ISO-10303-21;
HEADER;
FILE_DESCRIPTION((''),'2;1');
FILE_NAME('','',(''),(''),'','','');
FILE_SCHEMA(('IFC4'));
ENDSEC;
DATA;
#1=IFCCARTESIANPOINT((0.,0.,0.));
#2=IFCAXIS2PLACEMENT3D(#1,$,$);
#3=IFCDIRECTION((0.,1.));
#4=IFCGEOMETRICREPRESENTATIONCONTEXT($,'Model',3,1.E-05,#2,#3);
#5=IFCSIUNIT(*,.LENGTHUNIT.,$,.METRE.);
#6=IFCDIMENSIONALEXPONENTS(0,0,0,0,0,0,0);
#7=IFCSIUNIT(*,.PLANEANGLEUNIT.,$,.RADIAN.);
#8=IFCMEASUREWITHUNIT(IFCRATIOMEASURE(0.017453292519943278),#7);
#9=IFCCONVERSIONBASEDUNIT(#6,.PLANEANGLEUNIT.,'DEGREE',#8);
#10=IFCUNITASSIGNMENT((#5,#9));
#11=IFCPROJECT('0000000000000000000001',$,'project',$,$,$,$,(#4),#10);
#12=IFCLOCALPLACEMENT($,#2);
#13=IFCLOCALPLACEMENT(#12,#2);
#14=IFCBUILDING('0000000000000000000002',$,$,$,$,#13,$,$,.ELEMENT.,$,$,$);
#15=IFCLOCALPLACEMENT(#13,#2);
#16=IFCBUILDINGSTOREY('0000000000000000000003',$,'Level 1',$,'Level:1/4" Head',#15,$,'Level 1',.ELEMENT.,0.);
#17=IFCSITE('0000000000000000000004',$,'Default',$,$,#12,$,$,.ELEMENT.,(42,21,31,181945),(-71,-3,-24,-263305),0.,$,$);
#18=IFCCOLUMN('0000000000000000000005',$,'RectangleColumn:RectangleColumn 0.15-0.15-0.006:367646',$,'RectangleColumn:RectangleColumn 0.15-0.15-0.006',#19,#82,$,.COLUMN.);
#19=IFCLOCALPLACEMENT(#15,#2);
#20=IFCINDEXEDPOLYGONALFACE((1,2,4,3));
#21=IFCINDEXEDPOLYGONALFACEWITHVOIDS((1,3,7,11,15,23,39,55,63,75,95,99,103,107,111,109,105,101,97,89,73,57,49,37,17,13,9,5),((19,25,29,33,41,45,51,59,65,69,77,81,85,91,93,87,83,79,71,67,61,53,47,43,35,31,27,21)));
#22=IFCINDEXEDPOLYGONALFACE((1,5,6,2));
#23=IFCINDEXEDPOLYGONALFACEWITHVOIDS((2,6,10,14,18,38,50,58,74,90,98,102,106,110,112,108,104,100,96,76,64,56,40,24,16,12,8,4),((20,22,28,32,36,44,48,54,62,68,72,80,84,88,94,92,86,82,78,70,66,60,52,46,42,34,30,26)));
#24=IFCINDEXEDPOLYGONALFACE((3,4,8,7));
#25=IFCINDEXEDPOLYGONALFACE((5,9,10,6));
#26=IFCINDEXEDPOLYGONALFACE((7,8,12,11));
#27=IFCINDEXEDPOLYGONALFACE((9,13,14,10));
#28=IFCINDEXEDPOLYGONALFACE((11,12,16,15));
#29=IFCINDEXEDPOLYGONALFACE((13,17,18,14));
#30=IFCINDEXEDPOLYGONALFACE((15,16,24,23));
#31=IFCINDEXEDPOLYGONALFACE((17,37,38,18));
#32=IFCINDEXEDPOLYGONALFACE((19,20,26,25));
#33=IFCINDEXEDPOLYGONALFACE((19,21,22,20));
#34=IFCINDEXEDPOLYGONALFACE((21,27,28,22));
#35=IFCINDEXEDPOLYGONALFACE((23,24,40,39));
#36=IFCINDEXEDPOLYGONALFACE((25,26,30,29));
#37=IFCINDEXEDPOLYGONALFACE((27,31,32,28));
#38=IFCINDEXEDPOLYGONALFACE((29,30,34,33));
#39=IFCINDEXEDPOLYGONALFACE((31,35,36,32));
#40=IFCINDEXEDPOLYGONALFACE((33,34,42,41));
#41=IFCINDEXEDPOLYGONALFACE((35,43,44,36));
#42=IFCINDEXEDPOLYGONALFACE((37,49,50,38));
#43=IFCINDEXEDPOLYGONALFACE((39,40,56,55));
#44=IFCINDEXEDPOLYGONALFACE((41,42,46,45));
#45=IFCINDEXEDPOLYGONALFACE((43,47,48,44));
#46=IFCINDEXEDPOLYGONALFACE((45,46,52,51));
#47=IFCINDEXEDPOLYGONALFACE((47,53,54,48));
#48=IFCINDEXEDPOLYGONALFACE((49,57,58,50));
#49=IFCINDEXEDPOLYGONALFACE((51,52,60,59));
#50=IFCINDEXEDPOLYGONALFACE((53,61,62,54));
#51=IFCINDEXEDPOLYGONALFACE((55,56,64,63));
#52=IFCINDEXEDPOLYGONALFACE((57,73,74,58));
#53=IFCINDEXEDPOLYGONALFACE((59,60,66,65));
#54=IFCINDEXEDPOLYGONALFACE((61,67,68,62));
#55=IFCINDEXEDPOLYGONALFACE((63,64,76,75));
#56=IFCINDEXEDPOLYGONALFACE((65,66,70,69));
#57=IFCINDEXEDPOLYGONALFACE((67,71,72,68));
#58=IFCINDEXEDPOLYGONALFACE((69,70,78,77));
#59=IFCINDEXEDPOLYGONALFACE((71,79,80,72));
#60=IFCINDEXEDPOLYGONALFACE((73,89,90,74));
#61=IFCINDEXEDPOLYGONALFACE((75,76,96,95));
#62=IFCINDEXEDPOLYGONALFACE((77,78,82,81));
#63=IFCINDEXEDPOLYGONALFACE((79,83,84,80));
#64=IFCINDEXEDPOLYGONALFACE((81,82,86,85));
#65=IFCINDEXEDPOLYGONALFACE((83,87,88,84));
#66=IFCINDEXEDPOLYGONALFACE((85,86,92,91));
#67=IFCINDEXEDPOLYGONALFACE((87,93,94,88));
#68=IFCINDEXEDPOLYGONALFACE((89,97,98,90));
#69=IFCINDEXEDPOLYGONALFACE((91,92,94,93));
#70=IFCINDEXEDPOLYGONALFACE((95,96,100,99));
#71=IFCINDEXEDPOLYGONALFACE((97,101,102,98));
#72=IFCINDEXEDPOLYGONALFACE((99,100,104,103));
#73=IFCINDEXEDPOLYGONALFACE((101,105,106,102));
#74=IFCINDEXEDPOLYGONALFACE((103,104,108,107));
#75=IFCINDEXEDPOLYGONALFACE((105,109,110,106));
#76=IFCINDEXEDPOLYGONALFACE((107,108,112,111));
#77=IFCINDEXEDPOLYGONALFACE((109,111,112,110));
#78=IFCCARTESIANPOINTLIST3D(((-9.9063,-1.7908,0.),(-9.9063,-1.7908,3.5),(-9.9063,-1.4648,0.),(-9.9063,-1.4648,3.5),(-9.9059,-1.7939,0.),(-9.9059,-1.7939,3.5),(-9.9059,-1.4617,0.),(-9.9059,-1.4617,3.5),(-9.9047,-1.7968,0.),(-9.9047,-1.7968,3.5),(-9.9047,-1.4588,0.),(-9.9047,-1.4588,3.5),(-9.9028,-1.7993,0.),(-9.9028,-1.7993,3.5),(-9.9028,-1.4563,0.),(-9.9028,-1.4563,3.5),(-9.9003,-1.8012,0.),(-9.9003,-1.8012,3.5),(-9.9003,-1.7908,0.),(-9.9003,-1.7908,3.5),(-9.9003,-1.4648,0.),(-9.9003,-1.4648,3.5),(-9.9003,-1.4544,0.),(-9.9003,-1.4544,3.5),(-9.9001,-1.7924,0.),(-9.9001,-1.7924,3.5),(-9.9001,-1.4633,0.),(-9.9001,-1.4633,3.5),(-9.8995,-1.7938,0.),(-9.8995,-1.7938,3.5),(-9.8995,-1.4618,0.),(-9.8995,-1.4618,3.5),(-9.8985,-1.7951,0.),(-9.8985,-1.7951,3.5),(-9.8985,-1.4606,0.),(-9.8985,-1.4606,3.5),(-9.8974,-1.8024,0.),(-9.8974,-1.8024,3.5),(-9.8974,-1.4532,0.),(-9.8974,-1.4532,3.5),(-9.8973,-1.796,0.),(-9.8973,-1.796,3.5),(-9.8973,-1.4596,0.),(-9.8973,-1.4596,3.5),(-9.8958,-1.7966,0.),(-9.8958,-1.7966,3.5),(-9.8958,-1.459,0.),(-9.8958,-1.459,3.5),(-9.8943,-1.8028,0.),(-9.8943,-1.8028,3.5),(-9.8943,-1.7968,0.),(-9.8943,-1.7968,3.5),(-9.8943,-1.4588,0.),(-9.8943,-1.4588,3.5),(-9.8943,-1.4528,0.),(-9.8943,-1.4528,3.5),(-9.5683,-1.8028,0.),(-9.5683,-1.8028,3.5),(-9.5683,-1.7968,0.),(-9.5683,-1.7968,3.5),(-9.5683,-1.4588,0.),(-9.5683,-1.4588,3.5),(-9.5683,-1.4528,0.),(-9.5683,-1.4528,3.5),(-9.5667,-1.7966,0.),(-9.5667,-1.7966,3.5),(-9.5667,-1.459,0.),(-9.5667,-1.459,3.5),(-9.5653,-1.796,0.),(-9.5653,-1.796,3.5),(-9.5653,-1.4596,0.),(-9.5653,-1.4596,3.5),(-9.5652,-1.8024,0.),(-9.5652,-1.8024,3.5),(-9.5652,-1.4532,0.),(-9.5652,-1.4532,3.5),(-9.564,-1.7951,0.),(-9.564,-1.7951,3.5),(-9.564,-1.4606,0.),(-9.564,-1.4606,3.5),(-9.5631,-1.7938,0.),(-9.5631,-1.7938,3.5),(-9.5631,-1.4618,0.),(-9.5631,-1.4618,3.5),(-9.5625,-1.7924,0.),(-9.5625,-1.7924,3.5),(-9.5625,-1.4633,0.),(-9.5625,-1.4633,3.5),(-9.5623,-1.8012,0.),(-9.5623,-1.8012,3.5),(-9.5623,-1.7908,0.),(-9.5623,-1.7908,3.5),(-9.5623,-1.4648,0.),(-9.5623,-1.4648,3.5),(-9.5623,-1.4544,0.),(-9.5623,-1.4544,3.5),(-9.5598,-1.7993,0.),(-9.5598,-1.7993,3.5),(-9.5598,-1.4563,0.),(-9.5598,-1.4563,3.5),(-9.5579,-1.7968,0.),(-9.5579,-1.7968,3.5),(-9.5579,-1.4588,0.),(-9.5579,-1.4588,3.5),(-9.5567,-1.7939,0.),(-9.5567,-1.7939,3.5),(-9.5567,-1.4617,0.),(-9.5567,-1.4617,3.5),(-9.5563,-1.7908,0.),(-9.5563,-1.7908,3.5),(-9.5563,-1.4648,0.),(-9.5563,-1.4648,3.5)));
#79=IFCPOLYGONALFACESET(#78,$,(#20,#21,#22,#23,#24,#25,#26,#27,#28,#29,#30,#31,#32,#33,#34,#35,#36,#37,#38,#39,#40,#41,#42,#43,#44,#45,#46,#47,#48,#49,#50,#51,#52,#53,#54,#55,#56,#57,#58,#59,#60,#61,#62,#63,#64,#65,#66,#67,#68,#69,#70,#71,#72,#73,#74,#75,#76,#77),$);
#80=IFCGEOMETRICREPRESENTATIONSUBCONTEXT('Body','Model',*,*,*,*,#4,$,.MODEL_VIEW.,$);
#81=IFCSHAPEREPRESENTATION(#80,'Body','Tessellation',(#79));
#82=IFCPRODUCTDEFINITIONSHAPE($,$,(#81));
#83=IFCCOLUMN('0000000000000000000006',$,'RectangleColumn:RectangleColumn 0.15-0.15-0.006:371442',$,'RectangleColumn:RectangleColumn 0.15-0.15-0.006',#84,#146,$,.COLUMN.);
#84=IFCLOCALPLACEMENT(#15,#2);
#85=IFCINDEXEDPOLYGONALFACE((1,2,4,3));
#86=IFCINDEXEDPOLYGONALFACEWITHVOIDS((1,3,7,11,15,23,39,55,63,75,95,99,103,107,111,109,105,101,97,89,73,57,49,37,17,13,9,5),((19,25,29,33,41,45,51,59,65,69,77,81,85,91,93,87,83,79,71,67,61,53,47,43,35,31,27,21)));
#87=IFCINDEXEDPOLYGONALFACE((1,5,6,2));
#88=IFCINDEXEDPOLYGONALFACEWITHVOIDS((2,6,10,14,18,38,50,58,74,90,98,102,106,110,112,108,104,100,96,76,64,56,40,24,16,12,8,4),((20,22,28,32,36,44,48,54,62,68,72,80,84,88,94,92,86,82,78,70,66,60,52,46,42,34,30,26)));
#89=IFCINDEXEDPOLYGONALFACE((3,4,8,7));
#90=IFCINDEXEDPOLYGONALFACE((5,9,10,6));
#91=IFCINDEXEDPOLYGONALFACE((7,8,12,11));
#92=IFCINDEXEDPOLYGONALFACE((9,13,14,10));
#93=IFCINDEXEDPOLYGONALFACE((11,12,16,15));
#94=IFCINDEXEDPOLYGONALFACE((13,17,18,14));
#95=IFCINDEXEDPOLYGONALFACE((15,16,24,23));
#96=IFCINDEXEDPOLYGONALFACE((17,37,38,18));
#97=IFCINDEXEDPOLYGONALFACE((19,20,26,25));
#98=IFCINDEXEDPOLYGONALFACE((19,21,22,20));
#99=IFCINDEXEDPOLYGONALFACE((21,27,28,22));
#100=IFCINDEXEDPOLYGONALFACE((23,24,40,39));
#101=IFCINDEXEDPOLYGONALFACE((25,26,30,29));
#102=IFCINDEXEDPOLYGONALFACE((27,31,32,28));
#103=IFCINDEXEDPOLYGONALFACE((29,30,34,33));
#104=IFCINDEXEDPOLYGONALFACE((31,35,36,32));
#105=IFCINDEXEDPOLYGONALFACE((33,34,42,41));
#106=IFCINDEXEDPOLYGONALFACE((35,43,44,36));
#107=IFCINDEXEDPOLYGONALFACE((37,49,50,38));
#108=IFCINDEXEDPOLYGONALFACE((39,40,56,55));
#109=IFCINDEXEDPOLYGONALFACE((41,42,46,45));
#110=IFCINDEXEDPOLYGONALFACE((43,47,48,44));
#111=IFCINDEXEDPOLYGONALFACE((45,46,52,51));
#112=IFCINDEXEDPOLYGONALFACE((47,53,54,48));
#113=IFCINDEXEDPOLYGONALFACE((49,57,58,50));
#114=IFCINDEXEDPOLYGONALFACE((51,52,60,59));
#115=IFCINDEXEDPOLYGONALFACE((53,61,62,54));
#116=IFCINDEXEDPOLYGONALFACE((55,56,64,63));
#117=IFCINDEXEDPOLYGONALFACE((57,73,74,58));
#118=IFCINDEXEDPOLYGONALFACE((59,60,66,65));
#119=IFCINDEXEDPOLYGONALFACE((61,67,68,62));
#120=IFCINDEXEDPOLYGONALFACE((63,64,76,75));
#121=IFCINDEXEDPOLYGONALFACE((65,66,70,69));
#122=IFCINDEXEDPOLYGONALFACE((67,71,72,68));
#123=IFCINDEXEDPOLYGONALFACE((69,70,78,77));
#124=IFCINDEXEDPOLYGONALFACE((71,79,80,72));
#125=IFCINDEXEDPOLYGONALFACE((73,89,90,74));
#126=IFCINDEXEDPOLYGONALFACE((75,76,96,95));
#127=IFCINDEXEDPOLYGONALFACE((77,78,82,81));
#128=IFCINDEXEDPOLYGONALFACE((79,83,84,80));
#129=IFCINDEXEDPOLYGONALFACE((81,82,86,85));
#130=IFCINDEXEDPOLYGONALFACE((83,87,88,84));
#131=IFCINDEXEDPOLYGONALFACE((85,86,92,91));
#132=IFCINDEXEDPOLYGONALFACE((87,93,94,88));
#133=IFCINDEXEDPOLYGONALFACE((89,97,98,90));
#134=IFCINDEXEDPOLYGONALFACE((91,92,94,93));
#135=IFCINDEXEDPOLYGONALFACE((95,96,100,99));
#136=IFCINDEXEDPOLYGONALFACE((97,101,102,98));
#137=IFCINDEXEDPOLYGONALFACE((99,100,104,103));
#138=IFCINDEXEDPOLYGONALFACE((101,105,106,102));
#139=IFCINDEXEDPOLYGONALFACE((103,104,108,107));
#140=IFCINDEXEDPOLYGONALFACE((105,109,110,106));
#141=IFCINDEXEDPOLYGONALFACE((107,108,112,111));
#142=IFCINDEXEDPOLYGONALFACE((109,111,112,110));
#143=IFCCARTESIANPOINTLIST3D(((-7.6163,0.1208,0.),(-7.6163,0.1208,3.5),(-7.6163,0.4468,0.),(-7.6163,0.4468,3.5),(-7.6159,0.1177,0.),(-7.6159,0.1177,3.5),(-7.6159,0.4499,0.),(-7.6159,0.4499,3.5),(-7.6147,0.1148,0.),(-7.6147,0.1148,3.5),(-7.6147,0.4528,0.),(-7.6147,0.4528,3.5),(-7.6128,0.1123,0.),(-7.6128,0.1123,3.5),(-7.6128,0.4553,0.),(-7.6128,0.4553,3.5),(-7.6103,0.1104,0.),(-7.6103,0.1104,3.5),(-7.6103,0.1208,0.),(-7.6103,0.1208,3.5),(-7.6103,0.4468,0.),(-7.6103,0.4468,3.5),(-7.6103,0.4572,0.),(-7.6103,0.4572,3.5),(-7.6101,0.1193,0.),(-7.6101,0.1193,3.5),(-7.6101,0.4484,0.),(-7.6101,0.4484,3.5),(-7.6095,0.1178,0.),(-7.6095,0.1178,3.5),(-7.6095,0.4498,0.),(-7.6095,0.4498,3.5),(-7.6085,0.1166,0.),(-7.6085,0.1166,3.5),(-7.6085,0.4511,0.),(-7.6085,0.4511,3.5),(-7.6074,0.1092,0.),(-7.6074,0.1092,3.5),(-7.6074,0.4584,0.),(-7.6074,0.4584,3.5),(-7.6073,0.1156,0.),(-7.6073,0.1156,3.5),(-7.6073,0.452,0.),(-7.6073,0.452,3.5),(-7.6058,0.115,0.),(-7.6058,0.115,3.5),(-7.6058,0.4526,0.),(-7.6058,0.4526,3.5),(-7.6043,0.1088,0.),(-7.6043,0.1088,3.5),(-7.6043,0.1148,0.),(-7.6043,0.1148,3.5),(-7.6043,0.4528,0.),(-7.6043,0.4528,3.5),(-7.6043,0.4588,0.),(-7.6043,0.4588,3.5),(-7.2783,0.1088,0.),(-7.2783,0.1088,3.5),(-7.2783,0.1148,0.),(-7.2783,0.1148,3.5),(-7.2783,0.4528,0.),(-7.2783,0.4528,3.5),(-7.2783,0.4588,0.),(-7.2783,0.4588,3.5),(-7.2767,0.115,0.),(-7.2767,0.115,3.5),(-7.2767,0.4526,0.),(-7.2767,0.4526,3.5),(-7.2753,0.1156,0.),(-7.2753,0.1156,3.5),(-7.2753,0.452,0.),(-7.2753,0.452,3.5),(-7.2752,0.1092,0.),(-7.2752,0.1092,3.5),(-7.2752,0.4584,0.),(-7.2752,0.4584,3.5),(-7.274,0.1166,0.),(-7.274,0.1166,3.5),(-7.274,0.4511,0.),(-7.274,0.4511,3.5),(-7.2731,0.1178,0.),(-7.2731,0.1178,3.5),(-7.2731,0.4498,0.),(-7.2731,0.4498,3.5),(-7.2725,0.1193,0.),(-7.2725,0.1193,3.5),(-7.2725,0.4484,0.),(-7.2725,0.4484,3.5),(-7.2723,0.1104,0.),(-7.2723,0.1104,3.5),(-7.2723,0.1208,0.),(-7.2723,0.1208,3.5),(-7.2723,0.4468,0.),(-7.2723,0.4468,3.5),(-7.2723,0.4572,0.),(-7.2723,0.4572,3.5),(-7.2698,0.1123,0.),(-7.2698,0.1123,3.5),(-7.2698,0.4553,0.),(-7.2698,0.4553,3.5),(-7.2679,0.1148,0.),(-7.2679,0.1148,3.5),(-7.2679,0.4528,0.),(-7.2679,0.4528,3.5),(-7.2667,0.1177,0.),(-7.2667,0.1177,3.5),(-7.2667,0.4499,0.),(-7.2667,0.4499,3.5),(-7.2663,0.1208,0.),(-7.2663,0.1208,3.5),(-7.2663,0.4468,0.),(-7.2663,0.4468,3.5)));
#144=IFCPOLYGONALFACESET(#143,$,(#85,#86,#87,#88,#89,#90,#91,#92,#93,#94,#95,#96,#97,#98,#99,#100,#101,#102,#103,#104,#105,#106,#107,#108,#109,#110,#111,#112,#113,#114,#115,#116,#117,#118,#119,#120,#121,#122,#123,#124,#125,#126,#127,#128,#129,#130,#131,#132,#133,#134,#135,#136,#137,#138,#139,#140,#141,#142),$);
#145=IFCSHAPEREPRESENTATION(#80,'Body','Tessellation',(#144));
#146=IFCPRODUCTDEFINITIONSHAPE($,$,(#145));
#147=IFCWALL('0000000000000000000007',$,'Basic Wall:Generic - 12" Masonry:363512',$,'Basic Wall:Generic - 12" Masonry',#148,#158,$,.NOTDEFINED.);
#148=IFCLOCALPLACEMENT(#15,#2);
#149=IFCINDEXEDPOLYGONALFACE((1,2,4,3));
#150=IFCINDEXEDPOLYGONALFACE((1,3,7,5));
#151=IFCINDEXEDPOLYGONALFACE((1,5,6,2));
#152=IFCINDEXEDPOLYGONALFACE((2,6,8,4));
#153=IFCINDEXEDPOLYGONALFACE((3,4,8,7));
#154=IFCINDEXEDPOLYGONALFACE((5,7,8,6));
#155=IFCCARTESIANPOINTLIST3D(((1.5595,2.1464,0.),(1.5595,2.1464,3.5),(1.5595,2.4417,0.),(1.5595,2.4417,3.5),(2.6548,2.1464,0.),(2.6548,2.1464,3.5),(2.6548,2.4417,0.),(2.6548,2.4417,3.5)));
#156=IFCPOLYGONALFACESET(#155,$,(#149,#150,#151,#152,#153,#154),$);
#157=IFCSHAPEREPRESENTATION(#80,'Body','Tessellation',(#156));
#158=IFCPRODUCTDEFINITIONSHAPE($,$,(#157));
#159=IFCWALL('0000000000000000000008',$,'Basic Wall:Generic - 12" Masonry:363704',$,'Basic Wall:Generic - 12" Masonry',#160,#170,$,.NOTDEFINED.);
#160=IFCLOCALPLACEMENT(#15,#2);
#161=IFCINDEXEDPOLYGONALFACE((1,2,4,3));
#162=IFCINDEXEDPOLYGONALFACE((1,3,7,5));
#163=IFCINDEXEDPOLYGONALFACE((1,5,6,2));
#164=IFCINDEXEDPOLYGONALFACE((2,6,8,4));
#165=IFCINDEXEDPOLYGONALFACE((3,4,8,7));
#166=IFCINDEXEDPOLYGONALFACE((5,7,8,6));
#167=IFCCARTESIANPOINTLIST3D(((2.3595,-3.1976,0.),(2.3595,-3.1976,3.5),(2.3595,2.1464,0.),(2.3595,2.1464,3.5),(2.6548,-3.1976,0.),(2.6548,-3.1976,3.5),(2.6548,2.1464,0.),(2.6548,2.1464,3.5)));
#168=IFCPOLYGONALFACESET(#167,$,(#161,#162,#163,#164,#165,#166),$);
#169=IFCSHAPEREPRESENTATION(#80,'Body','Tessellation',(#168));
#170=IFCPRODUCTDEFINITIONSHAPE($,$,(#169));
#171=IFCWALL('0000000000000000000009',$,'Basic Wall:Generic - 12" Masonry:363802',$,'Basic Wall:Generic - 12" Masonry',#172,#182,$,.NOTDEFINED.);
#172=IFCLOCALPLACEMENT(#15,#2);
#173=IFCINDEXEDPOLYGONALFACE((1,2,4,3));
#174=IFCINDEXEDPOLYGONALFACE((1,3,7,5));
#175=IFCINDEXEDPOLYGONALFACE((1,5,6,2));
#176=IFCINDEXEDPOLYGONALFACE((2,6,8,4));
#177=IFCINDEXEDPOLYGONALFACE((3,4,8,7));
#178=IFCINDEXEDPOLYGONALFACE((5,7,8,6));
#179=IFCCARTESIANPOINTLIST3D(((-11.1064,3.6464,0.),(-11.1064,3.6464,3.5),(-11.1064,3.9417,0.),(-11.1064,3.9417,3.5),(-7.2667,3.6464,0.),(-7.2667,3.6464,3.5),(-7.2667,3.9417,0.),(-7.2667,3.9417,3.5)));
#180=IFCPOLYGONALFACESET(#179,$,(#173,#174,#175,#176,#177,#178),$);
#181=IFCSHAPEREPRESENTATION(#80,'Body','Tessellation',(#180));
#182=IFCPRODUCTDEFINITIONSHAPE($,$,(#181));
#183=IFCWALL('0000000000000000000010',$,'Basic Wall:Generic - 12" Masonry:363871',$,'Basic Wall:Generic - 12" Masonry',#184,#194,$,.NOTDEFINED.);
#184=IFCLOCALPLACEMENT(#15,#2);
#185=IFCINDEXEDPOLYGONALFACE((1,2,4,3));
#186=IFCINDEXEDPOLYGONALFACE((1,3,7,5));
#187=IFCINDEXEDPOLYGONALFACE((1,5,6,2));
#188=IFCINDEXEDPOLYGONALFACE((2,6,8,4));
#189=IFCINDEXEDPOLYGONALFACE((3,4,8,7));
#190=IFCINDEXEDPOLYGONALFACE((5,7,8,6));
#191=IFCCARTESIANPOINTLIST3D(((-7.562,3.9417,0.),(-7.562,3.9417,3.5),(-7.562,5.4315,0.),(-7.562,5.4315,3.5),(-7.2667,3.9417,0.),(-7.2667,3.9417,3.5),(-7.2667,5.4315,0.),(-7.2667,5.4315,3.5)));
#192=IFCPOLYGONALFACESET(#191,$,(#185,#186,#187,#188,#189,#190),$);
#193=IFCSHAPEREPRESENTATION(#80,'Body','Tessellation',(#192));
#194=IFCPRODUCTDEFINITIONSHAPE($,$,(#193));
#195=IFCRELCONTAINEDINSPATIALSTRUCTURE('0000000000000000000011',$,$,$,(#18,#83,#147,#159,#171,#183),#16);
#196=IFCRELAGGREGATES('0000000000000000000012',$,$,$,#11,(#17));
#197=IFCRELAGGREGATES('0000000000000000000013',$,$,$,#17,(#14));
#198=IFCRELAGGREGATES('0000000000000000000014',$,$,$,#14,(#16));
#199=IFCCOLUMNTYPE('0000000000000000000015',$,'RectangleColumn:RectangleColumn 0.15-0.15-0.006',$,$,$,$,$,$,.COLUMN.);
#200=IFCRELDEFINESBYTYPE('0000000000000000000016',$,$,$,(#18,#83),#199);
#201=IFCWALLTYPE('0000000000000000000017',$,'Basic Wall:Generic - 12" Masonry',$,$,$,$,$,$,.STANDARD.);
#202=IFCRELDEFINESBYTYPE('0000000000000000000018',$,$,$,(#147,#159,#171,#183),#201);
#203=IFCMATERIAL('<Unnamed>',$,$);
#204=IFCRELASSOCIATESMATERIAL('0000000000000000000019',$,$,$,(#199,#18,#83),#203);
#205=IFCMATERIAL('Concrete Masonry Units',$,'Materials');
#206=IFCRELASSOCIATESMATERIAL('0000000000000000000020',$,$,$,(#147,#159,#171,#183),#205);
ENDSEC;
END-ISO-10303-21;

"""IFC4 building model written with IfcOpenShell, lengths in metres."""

from ifc_helpers import new_model, entity, si_unit, converted_unit, direction, frame, origin, place, context, subcontext, project, spatial, line, arc, indexed_curve, outline, extrude, source, transform, mapped, material, type_object, type_shapes, element, save


model = new_model("IFC4")

# Units and contexts
model_context = context("Model", 3, precision=1e-05, world=origin(), true_north=direction((0.0, 1.0)))
body_context = subcontext(model_context, "Body", "Model", "MODEL_VIEW")
ifc_project = project(units=[si_unit("LENGTHUNIT", "METRE"), converted_unit("PLANEANGLEUNIT", "DEGREE", entity("IfcRatioMeasure", 0.017453292519943278), si_unit("PLANEANGLEUNIT", "RADIAN"), dimensions=[0, 0, 0, 0, 0, 0, 0])], contexts=[model_context])

# Site, building, storey
site_placement = place(None, origin())
site = spatial("IfcSite", under=ifc_project, at=site_placement, Name="Default", CompositionType="ELEMENT", RefLatitude=(42, 21, 31, 181945), RefLongitude=(-71, -3, -24, -263305), RefElevation=0.0)
building_placement = place(site_placement, origin())
building = spatial("IfcBuilding", under=site, at=building_placement, CompositionType="ELEMENT")
storey_placement = place(building_placement, origin())
storey = spatial("IfcBuildingStorey", under=building, at=storey_placement, Name="Level 1", ObjectType="Level:1/4\" Head", LongName="Level 1", CompositionType="ELEMENT", Elevation=0.0)

# Columns
ifc_material_1 = material(Name="<Unnamed>")
column_type = type_object("IfcColumnType", Name="RectangleColumn:RectangleColumn 0.15-0.15-0.006", PredefinedType="COLUMN", material=ifc_material_1)
shared_shape = source(origin(), body_context, "Body", "SweptSolid", [
    extrude(outline(indexed_curve([(-0.163, -0.175), (0.163, -0.175), (0.1715, -0.1715), (0.175, -0.163), (0.175, 0.163), (0.1715, 0.1715), (0.163, 0.175), (-0.163, 0.175), (-0.1715, 0.1715), (-0.175, 0.163), (-0.175, -0.163), (-0.1715, -0.1715)], segments=[line(1, 2), arc(2, 3, 4), line(4, 5), arc(5, 6, 7), line(7, 8), arc(8, 9, 10), line(10, 11), arc(11, 12, 1)], self_intersect=False), holes=[indexed_curve([(-0.163, -0.169), (-0.1672, -0.1672), (-0.169, -0.163), (-0.169, 0.163), (-0.1672, 0.1672), (-0.163, 0.169), (0.163, 0.169), (0.1672, 0.1672), (0.169, 0.163), (0.169, -0.163), (0.1672, -0.1672), (0.163, -0.169)], segments=[arc(1, 2, 3), line(3, 4), arc(4, 5, 6), line(6, 7), arc(7, 8, 9), line(9, 10), arc(10, 11, 12), line(12, 1)], self_intersect=False)]), frame((0.0, 0.0, 0.0), z_axis=(0.0, 0.0, 1.0), x_axis=(-1.0, 0.0, 0.0)), (0.0, 0.0, 1.0), 3.5),
])
type_shapes(column_type, [shared_shape])
for number, where, name in (
    (1, (-9.7313, -1.6278, 0.0), "RectangleColumn:RectangleColumn 0.15-0.15-0.006:367646"),
    (2, (-7.4413, 0.2838, 0.0), "RectangleColumn:RectangleColumn 0.15-0.15-0.006:371442"),
):
    element("IfcColumn", number, at=place(storey_placement, frame(where)), inside=storey, type_object=column_type, material=ifc_material_1, Name=name, ObjectType="RectangleColumn:RectangleColumn 0.15-0.15-0.006", PredefinedType="COLUMN", context=body_context, shape_type="MappedRepresentation", body=[
        mapped(shared_shape, transform((0.0, 0.0, 0.0), scale=1.0)),
    ])

# Walls
ifc_material_2 = material(Name="Concrete Masonry Units", Category="Materials")
wall_type_1 = type_object("IfcWallType", Name="Basic Wall:Generic - 12\" Masonry", PredefinedType="STANDARD")
wall_1_placement = place(storey_placement, frame((2.6548, 2.2941, 0.0), z_axis=(0.0, 0.0, 1.0), x_axis=(-1.0, 0.0, 0.0)))
element("IfcWall", 3, at=wall_1_placement, inside=storey, type_object=wall_type_1, material=ifc_material_2, Name="Basic Wall:Generic - 12\" Masonry:363512", ObjectType="Basic Wall:Generic - 12\" Masonry", PredefinedType="NOTDEFINED", context=body_context, shape_type="SweptSolid", body=[
    extrude(outline(indexed_curve([(1.0953, 0.1476), (0.0, 0.1476), (0.0, -0.1476), (1.0953, -0.1476), (1.0953, 0.1476)], self_intersect=False)), origin(), (0.0, 0.0, 1.0), 3.5),
])
wall_2_placement = place(storey_placement, frame((2.5071, -3.1976, 0.0), z_axis=(0.0, 0.0, 1.0), x_axis=(0.0, 1.0, 0.0)))
element("IfcWall", 4, at=wall_2_placement, inside=storey, type_object=wall_type_1, material=ifc_material_2, Name="Basic Wall:Generic - 12\" Masonry:363704", ObjectType="Basic Wall:Generic - 12\" Masonry", PredefinedType="NOTDEFINED", context=body_context, shape_type="SweptSolid", body=[
    extrude(outline(indexed_curve([(5.344, 0.1476), (0.0, 0.1476), (0.0, -0.1476), (5.344, -0.1476), (5.344, 0.1476)], self_intersect=False)), origin(), (0.0, 0.0, 1.0), 3.5),
])
wall_3_placement = place(storey_placement, frame((-7.2667, 3.7941, 0.0), z_axis=(0.0, 0.0, 1.0), x_axis=(-1.0, 0.0, 0.0)))
element("IfcWall", 5, at=wall_3_placement, inside=storey, type_object=wall_type_1, material=ifc_material_2, Name="Basic Wall:Generic - 12\" Masonry:363802", ObjectType="Basic Wall:Generic - 12\" Masonry", PredefinedType="NOTDEFINED", context=body_context, shape_type="SweptSolid", body=[
    extrude(outline(indexed_curve([(3.8396, 0.1476), (0.0, 0.1476), (0.0, -0.1476), (3.8396, -0.1476), (3.8396, 0.1476)], self_intersect=False)), origin(), (0.0, 0.0, 1.0), 3.5),
])
wall_4_placement = place(storey_placement, frame((-7.4144, 5.4315, 0.0), z_axis=(0.0, 0.0, 1.0), x_axis=(0.0, -1.0, 0.0)))
element("IfcWall", 6, at=wall_4_placement, inside=storey, type_object=wall_type_1, material=ifc_material_2, Name="Basic Wall:Generic - 12\" Masonry:363871", ObjectType="Basic Wall:Generic - 12\" Masonry", PredefinedType="NOTDEFINED", context=body_context, shape_type="SweptSolid", body=[
    extrude(outline(indexed_curve([(1.4897, 0.1476), (0.0, 0.1476), (0.0, -0.1476), (1.4897, -0.1476), (1.4897, 0.1476)], self_intersect=False)), origin(), (0.0, 0.0, 1.0), 3.5),
])

save(model, "model.ifc")
